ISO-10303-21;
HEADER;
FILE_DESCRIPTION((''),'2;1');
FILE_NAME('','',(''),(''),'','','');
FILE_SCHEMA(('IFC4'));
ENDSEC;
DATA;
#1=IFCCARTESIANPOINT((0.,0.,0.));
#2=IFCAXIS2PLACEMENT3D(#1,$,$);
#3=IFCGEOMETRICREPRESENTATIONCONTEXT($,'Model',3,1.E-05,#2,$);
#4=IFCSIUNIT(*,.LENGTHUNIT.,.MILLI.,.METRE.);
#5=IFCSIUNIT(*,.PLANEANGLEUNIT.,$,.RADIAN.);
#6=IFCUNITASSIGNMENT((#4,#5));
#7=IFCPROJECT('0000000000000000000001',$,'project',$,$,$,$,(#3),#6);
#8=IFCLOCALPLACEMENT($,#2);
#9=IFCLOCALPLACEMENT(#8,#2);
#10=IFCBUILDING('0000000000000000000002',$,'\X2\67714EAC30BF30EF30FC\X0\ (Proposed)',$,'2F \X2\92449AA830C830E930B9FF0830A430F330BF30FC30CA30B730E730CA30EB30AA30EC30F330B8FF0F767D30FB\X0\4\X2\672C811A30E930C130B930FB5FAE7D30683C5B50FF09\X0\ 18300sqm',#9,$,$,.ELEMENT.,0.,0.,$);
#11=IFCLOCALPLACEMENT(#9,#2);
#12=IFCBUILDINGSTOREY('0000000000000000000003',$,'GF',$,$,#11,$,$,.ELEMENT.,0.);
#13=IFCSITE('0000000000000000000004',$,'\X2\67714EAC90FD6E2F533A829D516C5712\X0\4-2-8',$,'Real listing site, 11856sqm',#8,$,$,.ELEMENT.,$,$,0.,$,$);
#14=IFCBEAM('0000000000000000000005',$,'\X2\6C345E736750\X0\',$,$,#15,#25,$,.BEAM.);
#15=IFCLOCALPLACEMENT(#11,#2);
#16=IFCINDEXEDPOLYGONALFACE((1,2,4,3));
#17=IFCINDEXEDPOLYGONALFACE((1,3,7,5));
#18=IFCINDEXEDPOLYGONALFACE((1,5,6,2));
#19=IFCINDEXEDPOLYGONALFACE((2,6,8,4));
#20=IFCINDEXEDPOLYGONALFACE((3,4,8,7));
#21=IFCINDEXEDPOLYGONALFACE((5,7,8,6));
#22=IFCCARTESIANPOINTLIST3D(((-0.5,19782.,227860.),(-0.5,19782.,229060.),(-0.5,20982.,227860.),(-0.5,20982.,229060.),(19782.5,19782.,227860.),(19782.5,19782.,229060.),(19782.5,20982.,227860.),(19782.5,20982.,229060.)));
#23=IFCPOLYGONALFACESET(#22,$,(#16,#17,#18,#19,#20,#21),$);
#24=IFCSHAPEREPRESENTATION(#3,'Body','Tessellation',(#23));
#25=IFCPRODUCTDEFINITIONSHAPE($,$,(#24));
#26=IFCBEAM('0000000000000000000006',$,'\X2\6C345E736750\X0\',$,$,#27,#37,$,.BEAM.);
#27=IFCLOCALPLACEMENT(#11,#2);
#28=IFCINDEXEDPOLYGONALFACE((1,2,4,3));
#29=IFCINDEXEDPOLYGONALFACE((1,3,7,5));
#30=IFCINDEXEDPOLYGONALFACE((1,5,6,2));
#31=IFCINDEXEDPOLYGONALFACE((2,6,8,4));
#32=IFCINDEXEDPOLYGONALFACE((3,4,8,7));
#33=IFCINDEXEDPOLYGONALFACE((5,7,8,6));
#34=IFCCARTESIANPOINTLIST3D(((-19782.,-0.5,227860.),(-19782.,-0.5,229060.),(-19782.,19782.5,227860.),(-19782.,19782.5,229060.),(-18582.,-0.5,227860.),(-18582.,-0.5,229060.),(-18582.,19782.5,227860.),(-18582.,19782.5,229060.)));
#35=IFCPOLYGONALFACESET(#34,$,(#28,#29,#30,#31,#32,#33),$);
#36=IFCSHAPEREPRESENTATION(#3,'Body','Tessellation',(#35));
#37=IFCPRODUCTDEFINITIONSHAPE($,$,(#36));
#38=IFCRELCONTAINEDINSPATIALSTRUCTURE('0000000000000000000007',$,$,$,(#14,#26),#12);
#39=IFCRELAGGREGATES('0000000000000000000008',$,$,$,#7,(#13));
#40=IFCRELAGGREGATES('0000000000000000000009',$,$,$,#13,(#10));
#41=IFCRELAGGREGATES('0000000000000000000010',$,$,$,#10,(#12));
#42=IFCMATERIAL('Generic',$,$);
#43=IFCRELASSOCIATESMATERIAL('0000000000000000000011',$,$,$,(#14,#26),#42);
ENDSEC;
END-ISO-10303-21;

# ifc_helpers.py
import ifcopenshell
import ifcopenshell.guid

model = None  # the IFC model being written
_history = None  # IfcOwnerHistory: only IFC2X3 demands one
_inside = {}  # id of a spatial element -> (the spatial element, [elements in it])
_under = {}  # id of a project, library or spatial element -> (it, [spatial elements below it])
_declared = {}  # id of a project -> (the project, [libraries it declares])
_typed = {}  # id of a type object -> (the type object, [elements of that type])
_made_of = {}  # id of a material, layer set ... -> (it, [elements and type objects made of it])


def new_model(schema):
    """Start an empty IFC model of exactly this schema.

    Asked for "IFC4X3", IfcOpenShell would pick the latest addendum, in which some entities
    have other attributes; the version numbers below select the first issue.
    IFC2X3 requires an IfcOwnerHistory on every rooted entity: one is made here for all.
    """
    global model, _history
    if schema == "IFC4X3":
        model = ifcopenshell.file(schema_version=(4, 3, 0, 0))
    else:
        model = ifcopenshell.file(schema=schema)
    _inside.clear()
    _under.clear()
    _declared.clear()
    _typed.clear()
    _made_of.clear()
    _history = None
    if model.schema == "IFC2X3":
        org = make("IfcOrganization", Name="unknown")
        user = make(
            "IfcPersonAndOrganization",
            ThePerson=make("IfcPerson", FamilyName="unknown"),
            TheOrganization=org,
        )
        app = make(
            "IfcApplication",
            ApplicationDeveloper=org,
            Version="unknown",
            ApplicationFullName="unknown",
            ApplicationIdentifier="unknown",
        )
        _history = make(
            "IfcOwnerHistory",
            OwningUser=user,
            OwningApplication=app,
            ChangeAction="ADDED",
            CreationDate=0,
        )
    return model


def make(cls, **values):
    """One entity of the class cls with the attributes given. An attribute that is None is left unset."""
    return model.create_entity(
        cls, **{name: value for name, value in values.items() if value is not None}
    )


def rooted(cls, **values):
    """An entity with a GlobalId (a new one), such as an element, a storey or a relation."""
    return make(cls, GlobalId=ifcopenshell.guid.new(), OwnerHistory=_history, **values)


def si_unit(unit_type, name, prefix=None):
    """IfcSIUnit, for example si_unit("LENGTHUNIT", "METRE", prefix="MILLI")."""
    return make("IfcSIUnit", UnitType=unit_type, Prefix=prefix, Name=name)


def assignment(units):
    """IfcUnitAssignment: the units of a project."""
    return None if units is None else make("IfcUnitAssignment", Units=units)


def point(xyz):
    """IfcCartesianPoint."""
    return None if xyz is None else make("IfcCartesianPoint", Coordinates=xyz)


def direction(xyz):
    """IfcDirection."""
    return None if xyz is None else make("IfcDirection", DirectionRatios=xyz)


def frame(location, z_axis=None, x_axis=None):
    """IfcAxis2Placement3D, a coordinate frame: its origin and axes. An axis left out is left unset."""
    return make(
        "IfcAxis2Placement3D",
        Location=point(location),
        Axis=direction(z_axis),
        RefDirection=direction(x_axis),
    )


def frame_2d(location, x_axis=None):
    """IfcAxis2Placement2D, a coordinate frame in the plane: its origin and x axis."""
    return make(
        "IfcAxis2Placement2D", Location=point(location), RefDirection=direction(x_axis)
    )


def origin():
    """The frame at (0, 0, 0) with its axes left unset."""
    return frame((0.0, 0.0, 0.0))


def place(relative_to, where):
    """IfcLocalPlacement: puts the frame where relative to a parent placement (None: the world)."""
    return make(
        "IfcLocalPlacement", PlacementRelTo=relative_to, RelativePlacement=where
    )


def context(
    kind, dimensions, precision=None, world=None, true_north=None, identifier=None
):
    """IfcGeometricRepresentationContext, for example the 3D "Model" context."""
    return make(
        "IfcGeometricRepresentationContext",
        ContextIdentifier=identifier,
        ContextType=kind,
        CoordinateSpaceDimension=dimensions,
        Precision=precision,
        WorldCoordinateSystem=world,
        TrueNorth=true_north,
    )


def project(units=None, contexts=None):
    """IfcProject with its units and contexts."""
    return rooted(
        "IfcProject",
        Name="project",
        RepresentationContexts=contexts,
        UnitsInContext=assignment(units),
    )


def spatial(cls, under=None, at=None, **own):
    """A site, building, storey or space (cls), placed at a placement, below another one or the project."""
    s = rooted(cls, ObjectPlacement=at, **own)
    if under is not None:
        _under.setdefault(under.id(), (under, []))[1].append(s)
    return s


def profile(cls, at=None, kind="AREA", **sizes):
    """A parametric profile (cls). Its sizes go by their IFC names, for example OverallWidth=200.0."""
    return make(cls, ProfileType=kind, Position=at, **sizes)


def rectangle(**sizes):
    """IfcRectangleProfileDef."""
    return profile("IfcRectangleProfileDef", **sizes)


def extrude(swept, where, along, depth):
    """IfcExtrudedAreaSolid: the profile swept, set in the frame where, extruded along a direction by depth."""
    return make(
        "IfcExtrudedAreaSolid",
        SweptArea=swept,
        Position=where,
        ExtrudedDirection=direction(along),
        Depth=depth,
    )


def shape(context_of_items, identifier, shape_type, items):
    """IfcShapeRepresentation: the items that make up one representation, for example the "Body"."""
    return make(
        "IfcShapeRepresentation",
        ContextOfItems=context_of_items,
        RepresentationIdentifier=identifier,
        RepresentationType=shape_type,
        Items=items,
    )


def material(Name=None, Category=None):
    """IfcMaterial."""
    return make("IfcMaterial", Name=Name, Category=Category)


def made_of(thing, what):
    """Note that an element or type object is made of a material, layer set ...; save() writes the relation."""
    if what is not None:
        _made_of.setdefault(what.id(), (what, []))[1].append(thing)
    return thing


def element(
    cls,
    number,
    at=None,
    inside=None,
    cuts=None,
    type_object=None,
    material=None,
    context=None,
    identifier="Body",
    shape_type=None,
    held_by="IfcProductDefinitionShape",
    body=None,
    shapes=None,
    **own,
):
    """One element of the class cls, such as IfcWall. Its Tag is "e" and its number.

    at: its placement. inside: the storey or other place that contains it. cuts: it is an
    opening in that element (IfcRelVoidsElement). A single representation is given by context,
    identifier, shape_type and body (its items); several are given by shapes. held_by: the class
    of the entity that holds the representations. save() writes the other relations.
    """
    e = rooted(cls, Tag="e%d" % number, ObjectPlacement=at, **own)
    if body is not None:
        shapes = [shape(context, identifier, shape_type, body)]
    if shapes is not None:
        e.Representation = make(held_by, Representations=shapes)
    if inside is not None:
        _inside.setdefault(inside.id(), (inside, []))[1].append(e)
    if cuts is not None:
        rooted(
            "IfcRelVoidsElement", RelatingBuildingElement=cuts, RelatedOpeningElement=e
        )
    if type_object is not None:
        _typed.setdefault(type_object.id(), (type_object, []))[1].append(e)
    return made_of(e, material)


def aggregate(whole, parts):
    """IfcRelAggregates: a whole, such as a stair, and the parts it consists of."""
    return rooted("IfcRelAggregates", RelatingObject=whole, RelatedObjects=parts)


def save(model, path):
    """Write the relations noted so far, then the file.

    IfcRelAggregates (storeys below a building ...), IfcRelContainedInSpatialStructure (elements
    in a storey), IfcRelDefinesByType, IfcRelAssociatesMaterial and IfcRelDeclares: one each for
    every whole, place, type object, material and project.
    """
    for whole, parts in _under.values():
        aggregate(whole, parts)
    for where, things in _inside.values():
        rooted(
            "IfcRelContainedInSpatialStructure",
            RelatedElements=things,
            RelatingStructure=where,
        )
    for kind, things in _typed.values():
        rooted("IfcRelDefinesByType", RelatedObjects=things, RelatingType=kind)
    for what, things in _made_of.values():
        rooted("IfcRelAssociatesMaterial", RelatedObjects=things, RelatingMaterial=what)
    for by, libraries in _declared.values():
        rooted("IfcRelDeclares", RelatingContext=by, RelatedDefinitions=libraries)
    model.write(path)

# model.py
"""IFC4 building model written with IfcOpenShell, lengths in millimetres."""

from ifc_helpers import new_model, si_unit, frame, frame_2d, origin, place, context, project, spatial, rectangle, extrude, material, element, save


model = new_model("IFC4")

# Units and contexts
model_context = context("Model", 3, precision=1e-05, world=origin())
ifc_project = project(units=[si_unit("LENGTHUNIT", "METRE", prefix="MILLI"), si_unit("PLANEANGLEUNIT", "RADIAN")], contexts=[model_context])

# Site, building, storey
site_placement = place(None, origin())
site = spatial("IfcSite", under=ifc_project, at=site_placement, Name="東京都港区芝公園4-2-8", ObjectType="Real listing site, 11856sqm", CompositionType="ELEMENT", RefElevation=0.0)
building_placement = place(site_placement, origin())
building = spatial("IfcBuilding", under=site, at=building_placement, Name="東京タワー (Proposed)", ObjectType="2F 鉄骨トラス（インターナショナルオレンジ／白・4本脚ラチス・微細格子） 18300sqm", CompositionType="ELEMENT", ElevationOfRefHeight=0.0, ElevationOfTerrain=0.0)
storey_placement = place(building_placement, origin())
storey = spatial("IfcBuildingStorey", under=building, at=storey_placement, Name="GF", CompositionType="ELEMENT", Elevation=0.0)

# Shared definitions
ifc_material = material(Name="Generic")

# Beams
beam_1_placement = place(storey_placement, frame((0.0, 9891.0, 113930.0)))
element("IfcBeam", 1, at=beam_1_placement, inside=storey, material=ifc_material, Name="水平材", PredefinedType="BEAM", context=model_context, shape_type="SweptSolid", body=[
    extrude(rectangle(XDim=19783.0, YDim=1200.0, at=frame_2d((9891.0, 600.0))), frame((0.0, 9891.0, 113930.0)), (0.0, 0.0, 1.0), 1200.0),
])
beam_2_placement = place(storey_placement, frame((-9891.0, 0.0, 113930.0)))
element("IfcBeam", 2, at=beam_2_placement, inside=storey, material=ifc_material, Name="水平材", PredefinedType="BEAM", context=model_context, shape_type="SweptSolid", body=[
    extrude(rectangle(XDim=1200.0, YDim=19783.0, at=frame_2d((600.0, 9891.0))), frame((-9891.0, 0.0, 113930.0)), (0.0, 0.0, 1.0), 1200.0),
])

save(model, "model.ifc")
